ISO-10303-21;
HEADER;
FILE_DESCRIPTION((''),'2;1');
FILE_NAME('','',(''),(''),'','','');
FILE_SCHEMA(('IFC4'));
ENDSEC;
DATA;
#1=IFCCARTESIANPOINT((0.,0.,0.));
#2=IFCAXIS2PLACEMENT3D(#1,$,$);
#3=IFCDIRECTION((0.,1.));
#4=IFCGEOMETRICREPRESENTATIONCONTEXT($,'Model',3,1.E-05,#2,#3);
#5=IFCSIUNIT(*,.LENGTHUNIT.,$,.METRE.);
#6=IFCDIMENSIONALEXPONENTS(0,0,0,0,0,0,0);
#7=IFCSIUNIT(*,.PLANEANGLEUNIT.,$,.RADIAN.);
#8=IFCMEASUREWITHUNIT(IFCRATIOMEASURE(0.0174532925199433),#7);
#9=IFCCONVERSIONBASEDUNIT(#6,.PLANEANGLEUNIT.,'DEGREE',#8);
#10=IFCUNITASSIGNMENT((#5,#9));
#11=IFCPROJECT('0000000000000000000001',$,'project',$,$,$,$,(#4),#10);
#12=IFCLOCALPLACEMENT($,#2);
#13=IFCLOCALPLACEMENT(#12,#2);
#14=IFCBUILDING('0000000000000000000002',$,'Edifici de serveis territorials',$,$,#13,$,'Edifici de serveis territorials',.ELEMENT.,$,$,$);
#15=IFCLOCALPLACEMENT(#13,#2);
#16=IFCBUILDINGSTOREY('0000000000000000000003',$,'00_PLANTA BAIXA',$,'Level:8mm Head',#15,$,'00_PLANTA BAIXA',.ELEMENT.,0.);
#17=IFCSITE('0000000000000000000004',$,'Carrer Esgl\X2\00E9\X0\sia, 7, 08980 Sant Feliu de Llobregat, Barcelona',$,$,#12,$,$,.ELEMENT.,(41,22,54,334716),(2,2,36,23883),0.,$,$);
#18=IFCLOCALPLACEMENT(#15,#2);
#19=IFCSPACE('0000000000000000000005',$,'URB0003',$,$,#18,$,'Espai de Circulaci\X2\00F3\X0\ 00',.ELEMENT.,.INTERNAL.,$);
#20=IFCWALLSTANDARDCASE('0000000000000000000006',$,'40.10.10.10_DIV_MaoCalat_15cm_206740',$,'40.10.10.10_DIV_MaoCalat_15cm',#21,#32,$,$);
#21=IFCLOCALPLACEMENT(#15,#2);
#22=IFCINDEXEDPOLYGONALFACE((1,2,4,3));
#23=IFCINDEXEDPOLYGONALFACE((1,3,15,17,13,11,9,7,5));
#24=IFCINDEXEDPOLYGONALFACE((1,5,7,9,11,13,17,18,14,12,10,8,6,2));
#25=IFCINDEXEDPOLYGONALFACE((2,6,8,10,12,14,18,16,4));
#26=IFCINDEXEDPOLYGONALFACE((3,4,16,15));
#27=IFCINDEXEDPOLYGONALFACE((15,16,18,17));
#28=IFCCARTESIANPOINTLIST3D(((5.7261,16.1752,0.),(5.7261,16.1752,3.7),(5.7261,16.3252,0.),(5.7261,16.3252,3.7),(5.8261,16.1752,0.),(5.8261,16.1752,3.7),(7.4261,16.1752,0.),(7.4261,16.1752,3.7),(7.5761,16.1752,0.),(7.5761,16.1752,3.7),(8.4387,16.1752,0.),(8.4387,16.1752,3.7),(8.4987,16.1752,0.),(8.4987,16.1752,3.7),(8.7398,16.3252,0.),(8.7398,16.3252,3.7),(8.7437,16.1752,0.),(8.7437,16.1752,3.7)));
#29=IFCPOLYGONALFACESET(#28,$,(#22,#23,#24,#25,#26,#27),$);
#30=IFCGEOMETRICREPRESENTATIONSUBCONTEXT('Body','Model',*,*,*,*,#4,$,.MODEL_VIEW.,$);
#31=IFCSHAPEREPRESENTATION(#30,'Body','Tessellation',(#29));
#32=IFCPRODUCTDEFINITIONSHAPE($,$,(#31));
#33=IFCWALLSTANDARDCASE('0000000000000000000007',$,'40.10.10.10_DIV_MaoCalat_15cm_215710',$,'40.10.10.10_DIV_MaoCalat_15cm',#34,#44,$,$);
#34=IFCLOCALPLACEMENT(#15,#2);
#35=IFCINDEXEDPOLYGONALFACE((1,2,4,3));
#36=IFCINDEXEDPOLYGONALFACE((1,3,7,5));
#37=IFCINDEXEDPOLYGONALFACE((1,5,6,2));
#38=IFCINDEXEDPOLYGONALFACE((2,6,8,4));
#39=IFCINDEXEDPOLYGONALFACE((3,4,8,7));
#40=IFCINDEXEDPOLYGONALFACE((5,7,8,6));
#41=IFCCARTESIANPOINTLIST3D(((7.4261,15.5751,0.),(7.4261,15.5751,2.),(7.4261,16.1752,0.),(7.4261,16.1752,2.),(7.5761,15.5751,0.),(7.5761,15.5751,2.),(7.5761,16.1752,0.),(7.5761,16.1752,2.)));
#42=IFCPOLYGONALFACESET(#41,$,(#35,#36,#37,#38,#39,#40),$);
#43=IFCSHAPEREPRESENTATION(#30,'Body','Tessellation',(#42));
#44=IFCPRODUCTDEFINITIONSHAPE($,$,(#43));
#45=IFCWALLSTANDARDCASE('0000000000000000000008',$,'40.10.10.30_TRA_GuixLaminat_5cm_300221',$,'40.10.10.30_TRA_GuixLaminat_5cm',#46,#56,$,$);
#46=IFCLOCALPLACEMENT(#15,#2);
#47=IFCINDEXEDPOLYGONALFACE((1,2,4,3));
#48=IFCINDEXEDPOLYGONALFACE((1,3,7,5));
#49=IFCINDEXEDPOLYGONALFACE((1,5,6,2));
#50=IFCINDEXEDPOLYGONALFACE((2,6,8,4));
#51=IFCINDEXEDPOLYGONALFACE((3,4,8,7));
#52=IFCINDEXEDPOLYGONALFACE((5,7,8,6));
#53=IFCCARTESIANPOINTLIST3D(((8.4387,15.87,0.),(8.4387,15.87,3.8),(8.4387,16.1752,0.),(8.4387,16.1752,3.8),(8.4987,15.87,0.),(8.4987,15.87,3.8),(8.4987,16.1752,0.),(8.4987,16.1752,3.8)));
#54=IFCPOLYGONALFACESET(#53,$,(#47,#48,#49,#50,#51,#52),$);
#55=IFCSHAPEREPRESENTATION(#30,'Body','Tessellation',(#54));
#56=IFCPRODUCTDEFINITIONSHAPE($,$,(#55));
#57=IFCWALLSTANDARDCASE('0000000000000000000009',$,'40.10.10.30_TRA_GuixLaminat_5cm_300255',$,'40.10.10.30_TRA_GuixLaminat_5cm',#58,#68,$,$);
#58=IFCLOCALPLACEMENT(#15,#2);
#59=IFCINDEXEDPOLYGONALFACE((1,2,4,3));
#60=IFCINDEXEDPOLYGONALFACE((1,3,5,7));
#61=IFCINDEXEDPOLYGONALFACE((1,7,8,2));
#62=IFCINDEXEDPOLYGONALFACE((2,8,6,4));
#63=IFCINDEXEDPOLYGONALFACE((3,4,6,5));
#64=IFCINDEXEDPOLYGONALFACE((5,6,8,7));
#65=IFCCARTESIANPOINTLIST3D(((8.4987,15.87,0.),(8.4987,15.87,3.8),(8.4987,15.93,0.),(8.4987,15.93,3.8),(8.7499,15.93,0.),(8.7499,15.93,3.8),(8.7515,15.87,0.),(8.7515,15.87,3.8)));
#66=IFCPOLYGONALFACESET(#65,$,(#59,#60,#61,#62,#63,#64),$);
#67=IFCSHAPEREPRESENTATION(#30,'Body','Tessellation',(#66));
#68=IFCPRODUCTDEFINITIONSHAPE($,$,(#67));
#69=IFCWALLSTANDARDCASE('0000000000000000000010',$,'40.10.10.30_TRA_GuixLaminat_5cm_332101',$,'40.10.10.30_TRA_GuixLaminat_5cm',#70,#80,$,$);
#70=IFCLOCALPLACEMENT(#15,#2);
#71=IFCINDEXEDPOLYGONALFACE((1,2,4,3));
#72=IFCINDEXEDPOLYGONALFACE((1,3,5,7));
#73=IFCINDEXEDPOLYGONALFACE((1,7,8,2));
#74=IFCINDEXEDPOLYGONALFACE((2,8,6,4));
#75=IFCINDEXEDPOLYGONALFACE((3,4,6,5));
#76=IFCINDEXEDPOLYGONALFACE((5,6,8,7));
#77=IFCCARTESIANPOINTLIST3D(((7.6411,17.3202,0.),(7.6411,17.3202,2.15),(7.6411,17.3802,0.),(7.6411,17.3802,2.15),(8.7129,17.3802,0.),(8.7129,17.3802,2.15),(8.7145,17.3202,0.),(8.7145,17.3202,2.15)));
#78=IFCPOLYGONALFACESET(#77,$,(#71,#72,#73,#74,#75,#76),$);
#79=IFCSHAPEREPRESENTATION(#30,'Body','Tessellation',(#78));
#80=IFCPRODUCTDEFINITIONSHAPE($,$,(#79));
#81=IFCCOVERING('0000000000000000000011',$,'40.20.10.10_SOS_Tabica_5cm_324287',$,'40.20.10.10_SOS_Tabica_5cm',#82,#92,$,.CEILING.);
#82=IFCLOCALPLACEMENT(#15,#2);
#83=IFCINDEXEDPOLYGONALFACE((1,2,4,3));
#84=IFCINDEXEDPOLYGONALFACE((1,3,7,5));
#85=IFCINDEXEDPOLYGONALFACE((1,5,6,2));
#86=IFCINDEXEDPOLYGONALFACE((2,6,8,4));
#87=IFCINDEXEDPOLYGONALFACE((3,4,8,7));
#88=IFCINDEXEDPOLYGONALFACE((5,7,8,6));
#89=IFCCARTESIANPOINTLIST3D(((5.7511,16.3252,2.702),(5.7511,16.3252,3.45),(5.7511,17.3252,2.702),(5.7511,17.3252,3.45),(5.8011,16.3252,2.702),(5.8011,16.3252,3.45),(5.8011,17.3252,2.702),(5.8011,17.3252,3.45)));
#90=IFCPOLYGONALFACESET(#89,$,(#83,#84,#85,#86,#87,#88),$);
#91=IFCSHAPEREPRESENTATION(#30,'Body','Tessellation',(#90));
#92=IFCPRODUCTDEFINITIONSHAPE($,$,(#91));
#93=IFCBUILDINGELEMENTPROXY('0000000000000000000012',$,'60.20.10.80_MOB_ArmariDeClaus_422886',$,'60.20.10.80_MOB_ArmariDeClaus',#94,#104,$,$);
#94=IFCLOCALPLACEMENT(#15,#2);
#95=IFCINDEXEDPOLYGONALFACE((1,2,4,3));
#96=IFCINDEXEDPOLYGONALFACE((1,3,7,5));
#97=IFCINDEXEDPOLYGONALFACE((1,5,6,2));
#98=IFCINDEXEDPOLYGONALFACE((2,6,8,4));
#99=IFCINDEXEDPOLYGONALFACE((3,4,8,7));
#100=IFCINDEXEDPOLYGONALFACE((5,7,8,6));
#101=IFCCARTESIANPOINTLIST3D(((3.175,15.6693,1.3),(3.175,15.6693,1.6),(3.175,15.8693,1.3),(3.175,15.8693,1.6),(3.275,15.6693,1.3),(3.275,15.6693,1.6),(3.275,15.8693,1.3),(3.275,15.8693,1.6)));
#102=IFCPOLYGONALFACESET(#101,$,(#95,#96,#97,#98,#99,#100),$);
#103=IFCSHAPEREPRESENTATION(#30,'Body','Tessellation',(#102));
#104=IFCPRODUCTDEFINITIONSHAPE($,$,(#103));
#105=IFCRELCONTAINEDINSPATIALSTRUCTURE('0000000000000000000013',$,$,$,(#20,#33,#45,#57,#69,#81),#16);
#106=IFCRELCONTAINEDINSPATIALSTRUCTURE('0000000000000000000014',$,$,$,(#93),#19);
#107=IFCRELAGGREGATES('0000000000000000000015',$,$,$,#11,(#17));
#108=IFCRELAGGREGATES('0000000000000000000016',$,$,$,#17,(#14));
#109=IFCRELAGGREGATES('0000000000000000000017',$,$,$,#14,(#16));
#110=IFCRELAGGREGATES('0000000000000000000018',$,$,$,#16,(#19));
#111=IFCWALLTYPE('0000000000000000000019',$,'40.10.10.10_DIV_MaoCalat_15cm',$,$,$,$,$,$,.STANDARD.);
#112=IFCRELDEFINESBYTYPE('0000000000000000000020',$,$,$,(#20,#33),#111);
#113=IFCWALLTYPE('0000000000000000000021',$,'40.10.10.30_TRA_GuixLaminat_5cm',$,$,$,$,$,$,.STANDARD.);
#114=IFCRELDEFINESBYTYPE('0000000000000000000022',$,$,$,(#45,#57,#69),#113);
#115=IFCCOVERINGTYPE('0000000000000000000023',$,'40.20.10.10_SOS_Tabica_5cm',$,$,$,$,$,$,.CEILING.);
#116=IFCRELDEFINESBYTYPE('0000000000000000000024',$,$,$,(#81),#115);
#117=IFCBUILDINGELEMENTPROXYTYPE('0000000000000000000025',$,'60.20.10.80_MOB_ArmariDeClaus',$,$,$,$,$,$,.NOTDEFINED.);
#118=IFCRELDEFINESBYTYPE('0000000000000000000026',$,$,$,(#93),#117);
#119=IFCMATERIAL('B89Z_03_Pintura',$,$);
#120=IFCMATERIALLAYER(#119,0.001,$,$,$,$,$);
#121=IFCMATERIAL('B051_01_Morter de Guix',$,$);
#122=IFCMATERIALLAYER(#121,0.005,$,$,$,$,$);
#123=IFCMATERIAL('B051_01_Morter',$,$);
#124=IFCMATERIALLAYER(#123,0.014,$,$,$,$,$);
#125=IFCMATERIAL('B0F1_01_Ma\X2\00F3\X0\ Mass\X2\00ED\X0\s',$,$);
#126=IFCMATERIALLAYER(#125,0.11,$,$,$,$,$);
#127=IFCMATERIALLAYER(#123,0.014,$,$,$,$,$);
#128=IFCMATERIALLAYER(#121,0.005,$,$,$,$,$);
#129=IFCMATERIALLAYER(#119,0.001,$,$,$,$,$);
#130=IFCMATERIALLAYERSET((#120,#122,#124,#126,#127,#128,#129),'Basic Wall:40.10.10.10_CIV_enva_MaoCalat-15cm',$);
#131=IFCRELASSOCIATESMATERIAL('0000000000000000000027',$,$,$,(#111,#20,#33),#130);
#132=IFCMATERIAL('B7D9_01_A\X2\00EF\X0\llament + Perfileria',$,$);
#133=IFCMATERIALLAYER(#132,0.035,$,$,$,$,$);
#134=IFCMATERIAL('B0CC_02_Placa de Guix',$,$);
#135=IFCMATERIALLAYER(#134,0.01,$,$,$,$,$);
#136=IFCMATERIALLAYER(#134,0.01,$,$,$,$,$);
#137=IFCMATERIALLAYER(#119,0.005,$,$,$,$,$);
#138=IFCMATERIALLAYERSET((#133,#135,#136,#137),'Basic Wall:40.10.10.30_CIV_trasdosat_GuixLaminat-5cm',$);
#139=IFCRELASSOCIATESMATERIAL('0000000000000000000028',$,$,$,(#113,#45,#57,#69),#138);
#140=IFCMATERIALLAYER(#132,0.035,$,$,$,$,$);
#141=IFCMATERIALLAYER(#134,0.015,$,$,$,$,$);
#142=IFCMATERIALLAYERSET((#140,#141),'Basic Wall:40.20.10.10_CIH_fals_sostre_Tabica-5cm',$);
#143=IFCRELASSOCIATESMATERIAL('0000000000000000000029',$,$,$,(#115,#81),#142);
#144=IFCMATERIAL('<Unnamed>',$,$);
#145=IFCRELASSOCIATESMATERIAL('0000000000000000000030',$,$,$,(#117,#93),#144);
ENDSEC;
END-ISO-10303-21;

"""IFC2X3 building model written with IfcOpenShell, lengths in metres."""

from ifc_helpers import new_model, entity, si_unit, converted_unit, direction, frame, frame_2d, origin, origin_2d_with_axis, place, context, subcontext, project, spatial, polyline, rectangle, outline, extrude, source, transform, mapped, material, layer, layer_set, layer_usage, type_object, type_shapes, element, save


model = new_model("IFC2X3")

# Units and contexts
model_context = context("Model", 3, precision=1e-05, world=origin(), true_north=direction((0.0, 1.0)))
body_context = subcontext(model_context, "Body", "Model", "MODEL_VIEW")
ifc_project = project(units=[si_unit("LENGTHUNIT", "METRE"), converted_unit("PLANEANGLEUNIT", "DEGREE", entity("IfcRatioMeasure", 0.0174532925199433), si_unit("PLANEANGLEUNIT", "RADIAN"), dimensions=[0, 0, 0, 0, 0, 0, 0])], contexts=[model_context])

# Site, building, storey
site_placement = place(None, origin())
site = spatial("IfcSite", under=ifc_project, at=site_placement, Name="Carrer Església, 7, 08980 Sant Feliu de Llobregat, Barcelona", CompositionType="ELEMENT", RefLatitude=(41, 22, 54, 334716), RefLongitude=(2, 2, 36, 23883), RefElevation=0.0)
building_placement = place(site_placement, origin())
building = spatial("IfcBuilding", under=site, at=building_placement, Name="Edifici de serveis territorials", LongName="Edifici de serveis territorials", CompositionType="ELEMENT")
storey_placement = place(building_placement, origin())
storey = spatial("IfcBuildingStorey", under=building, at=storey_placement, Name="00_PLANTA BAIXA", ObjectType="Level:8mm Head", LongName="00_PLANTA BAIXA", CompositionType="ELEMENT", Elevation=0.0)

# Shared definitions
ifc_material_1 = material(Name="B89Z_03_Pintura")
ifc_material_2 = material(Name="B0CC_02_Placa de Guix")
ifc_material_3 = material(Name="B7D9_01_Aïllament + Perfileria")

# Walls
ifc_layer_1 = layer(ifc_material_1, 0.001)
ifc_material_4 = material(Name="B051_01_Morter de Guix")
ifc_layer_2 = layer(ifc_material_4, 0.005)
ifc_material_5 = material(Name="B051_01_Morter")
ifc_layer_3 = layer(ifc_material_5, 0.014)
ifc_material_6 = material(Name="B0F1_01_Maó Massís")
ifc_layer_4 = layer(ifc_material_6, 0.11)
ifc_layer_5 = layer(ifc_material_5, 0.014)
ifc_layer_6 = layer(ifc_material_4, 0.005)
ifc_layer_7 = layer(ifc_material_1, 0.001)
ifc_layer_set_1 = layer_set([ifc_layer_1, ifc_layer_2, ifc_layer_3, ifc_layer_4, ifc_layer_5, ifc_layer_6, ifc_layer_7], Name="Basic Wall:40.10.10.10_CIV_enva_MaoCalat-15cm")
ifc_layer_usage_1 = layer_usage(ifc_layer_set_1, "AXIS2", "NEGATIVE", 0.075)
wall_type_1 = type_object("IfcWallType", Name="40.10.10.10_DIV_MaoCalat_15cm", PredefinedType="STANDARD", material=ifc_layer_set_1)
wall_1_placement = place(storey_placement, frame((8.7437, 16.2502, 0.0), z_axis=(0.0, 0.0, 1.0), x_axis=(-1.0, 0.0, 0.0)))
element("IfcWallStandardCase", 1, at=wall_1_placement, inside=storey, type_object=wall_type_1, material=ifc_layer_usage_1, Name="40.10.10.10_DIV_MaoCalat_15cm_206740", ObjectType="40.10.10.10_DIV_MaoCalat_15cm", context=body_context, shape_type="SweptSolid", body=[
    extrude(outline(polyline([(3.0176, -0.075), (3.0176, 0.075), (2.9176, 0.075), (1.3176, 0.075), (1.1676, 0.075), (0.305, 0.075), (0.245, 0.075), (0.0, 0.075), (0.0038, -0.075), (3.0176, -0.075)])), origin(), (0.0, 0.0, 1.0), 3.7),
])
ifc_layer_usage_2 = layer_usage(ifc_layer_set_1, "AXIS2", "NEGATIVE", 0.075)
wall_2_placement = place(storey_placement, frame((7.5011, 16.1752, 0.0), z_axis=(0.0, 0.0, 1.0), x_axis=(0.0, -1.0, 0.0)))
element("IfcWallStandardCase", 2, at=wall_2_placement, inside=storey, type_object=wall_type_1, material=ifc_layer_usage_2, Name="40.10.10.10_DIV_MaoCalat_15cm_215710", ObjectType="40.10.10.10_DIV_MaoCalat_15cm", context=body_context, shape_type="SweptSolid", body=[
    extrude(rectangle(XDim=0.6001, YDim=0.15, at=frame_2d((0.3, 0.0), x_axis=(-1.0, 0.0))), origin(), (0.0, 0.0, 1.0), 2.0),
])
ifc_layer_8 = layer(ifc_material_3, 0.035)
ifc_layer_9 = layer(ifc_material_2, 0.01)
ifc_layer_10 = layer(ifc_material_2, 0.01)
ifc_layer_11 = layer(ifc_material_1, 0.005)
ifc_layer_set_2 = layer_set([ifc_layer_8, ifc_layer_9, ifc_layer_10, ifc_layer_11], Name="Basic Wall:40.10.10.30_CIV_trasdosat_GuixLaminat-5cm")
ifc_layer_usage_3 = layer_usage(ifc_layer_set_2, "AXIS2", "NEGATIVE", 0.03)
wall_type_2 = type_object("IfcWallType", Name="40.10.10.30_TRA_GuixLaminat_5cm", PredefinedType="STANDARD", material=ifc_layer_set_2)
wall_3_placement = place(storey_placement, frame((8.4687, 16.1752, 0.0), z_axis=(0.0, 0.0, 1.0), x_axis=(0.0, -1.0, 0.0)))
element("IfcWallStandardCase", 3, at=wall_3_placement, inside=storey, type_object=wall_type_2, material=ifc_layer_usage_3, Name="40.10.10.30_TRA_GuixLaminat_5cm_300221", ObjectType="40.10.10.30_TRA_GuixLaminat_5cm", context=body_context, shape_type="SweptSolid", body=[
    extrude(rectangle(XDim=0.3052, YDim=0.06, at=frame_2d((0.1526, 0.0), x_axis=(-1.0, 0.0))), origin(), (0.0, 0.0, 1.0), 3.8),
])
ifc_layer_usage_4 = layer_usage(ifc_layer_set_2, "AXIS2", "NEGATIVE", 0.03)
wall_4_placement = place(storey_placement, frame((8.4987, 15.9, 0.0)))
element("IfcWallStandardCase", 4, at=wall_4_placement, inside=storey, type_object=wall_type_2, material=ifc_layer_usage_4, Name="40.10.10.30_TRA_GuixLaminat_5cm_300255", ObjectType="40.10.10.30_TRA_GuixLaminat_5cm", context=body_context, shape_type="SweptSolid", body=[
    extrude(outline(polyline([(0.2528, -0.03), (0.2513, 0.03), (0.0, 0.03), (0.0, -0.03), (0.2528, -0.03)])), origin(), (0.0, 0.0, 1.0), 3.8),
])
ifc_layer_usage_5 = layer_usage(ifc_layer_set_2, "AXIS2", "NEGATIVE", 0.03)
wall_5_placement = place(storey_placement, frame((7.6411, 17.3502, 0.0)))
element("IfcWallStandardCase", 5, at=wall_5_placement, inside=storey, type_object=wall_type_2, material=ifc_layer_usage_5, Name="40.10.10.30_TRA_GuixLaminat_5cm_332101", ObjectType="40.10.10.30_TRA_GuixLaminat_5cm", context=body_context, shape_type="SweptSolid", body=[
    extrude(outline(polyline([(1.0734, -0.03), (1.0719, 0.03), (0.0, 0.03), (0.0, -0.03), (1.0734, -0.03)])), origin(), (0.0, 0.0, 1.0), 2.15),
])

# Covering
ifc_layer_12 = layer(ifc_material_3, 0.035)
ifc_layer_13 = layer(ifc_material_2, 0.015)
ifc_layer_set_3 = layer_set([ifc_layer_12, ifc_layer_13], Name="Basic Wall:40.20.10.10_CIH_fals_sostre_Tabica-5cm")
ifc_layer_usage_6 = layer_usage(ifc_layer_set_3, "AXIS2", "POSITIVE", -0.025)
covering_type = type_object("IfcCoveringType", Name="40.20.10.10_SOS_Tabica_5cm", PredefinedType="CEILING", material=ifc_layer_set_3)
covering_placement = place(storey_placement, frame((5.7761, 17.3252, 2.702), z_axis=(0.0, 0.0, 1.0), x_axis=(0.0, -1.0, 0.0)))
element("IfcCovering", 6, at=covering_placement, inside=storey, type_object=covering_type, material=ifc_layer_usage_6, Name="40.20.10.10_SOS_Tabica_5cm_324287", ObjectType="40.20.10.10_SOS_Tabica_5cm", PredefinedType="CEILING", context=body_context, shape_type="SweptSolid", body=[
    extrude(rectangle(XDim=1.0, YDim=0.05, at=frame_2d((0.5, 0.0), x_axis=(-1.0, 0.0))), origin(), (0.0, 0.0, 1.0), 0.748),
])

# Shared definitions
space_placement = place(storey_placement, origin())
space = spatial("IfcSpace", under=storey, at=space_placement, Name="URB0003", LongName="Espai de Circulació 00", CompositionType="ELEMENT", InteriorOrExteriorSpace="INTERNAL")

# Building element proxy
ifc_material_7 = material(Name="<Unnamed>")
building_element_proxy_type = type_object("IfcBuildingElementProxyType", Name="60.20.10.80_MOB_ArmariDeClaus", PredefinedType="NOTDEFINED", material=ifc_material_7)
shared_shape_1 = source(origin(), body_context, "Body", "SweptSolid", [
    extrude(rectangle(XDim=0.2, YDim=0.1, at=origin_2d_with_axis()), frame((0.0, 0.0, 0.0), z_axis=(0.0, 0.0, 1.0), x_axis=(-1.0, 0.0, 0.0)), (0.0, 0.0, 1.0), 0.3),
])
type_shapes(building_element_proxy_type, [shared_shape_1])
proxy_placement = place(space_placement, frame((3.225, 15.7693, 1.3), z_axis=(0.0, 0.0, 1.0), x_axis=(0.0, 1.0, 0.0)))
element("IfcBuildingElementProxy", 7, at=proxy_placement, inside=space, type_object=building_element_proxy_type, material=ifc_material_7, Name="60.20.10.80_MOB_ArmariDeClaus_422886", ObjectType="60.20.10.80_MOB_ArmariDeClaus", context=body_context, shape_type="MappedRepresentation", body=[
    mapped(shared_shape_1, transform((0.0, 0.0, 0.0), scale=1.0)),
])

save(model, "model.ifc")
